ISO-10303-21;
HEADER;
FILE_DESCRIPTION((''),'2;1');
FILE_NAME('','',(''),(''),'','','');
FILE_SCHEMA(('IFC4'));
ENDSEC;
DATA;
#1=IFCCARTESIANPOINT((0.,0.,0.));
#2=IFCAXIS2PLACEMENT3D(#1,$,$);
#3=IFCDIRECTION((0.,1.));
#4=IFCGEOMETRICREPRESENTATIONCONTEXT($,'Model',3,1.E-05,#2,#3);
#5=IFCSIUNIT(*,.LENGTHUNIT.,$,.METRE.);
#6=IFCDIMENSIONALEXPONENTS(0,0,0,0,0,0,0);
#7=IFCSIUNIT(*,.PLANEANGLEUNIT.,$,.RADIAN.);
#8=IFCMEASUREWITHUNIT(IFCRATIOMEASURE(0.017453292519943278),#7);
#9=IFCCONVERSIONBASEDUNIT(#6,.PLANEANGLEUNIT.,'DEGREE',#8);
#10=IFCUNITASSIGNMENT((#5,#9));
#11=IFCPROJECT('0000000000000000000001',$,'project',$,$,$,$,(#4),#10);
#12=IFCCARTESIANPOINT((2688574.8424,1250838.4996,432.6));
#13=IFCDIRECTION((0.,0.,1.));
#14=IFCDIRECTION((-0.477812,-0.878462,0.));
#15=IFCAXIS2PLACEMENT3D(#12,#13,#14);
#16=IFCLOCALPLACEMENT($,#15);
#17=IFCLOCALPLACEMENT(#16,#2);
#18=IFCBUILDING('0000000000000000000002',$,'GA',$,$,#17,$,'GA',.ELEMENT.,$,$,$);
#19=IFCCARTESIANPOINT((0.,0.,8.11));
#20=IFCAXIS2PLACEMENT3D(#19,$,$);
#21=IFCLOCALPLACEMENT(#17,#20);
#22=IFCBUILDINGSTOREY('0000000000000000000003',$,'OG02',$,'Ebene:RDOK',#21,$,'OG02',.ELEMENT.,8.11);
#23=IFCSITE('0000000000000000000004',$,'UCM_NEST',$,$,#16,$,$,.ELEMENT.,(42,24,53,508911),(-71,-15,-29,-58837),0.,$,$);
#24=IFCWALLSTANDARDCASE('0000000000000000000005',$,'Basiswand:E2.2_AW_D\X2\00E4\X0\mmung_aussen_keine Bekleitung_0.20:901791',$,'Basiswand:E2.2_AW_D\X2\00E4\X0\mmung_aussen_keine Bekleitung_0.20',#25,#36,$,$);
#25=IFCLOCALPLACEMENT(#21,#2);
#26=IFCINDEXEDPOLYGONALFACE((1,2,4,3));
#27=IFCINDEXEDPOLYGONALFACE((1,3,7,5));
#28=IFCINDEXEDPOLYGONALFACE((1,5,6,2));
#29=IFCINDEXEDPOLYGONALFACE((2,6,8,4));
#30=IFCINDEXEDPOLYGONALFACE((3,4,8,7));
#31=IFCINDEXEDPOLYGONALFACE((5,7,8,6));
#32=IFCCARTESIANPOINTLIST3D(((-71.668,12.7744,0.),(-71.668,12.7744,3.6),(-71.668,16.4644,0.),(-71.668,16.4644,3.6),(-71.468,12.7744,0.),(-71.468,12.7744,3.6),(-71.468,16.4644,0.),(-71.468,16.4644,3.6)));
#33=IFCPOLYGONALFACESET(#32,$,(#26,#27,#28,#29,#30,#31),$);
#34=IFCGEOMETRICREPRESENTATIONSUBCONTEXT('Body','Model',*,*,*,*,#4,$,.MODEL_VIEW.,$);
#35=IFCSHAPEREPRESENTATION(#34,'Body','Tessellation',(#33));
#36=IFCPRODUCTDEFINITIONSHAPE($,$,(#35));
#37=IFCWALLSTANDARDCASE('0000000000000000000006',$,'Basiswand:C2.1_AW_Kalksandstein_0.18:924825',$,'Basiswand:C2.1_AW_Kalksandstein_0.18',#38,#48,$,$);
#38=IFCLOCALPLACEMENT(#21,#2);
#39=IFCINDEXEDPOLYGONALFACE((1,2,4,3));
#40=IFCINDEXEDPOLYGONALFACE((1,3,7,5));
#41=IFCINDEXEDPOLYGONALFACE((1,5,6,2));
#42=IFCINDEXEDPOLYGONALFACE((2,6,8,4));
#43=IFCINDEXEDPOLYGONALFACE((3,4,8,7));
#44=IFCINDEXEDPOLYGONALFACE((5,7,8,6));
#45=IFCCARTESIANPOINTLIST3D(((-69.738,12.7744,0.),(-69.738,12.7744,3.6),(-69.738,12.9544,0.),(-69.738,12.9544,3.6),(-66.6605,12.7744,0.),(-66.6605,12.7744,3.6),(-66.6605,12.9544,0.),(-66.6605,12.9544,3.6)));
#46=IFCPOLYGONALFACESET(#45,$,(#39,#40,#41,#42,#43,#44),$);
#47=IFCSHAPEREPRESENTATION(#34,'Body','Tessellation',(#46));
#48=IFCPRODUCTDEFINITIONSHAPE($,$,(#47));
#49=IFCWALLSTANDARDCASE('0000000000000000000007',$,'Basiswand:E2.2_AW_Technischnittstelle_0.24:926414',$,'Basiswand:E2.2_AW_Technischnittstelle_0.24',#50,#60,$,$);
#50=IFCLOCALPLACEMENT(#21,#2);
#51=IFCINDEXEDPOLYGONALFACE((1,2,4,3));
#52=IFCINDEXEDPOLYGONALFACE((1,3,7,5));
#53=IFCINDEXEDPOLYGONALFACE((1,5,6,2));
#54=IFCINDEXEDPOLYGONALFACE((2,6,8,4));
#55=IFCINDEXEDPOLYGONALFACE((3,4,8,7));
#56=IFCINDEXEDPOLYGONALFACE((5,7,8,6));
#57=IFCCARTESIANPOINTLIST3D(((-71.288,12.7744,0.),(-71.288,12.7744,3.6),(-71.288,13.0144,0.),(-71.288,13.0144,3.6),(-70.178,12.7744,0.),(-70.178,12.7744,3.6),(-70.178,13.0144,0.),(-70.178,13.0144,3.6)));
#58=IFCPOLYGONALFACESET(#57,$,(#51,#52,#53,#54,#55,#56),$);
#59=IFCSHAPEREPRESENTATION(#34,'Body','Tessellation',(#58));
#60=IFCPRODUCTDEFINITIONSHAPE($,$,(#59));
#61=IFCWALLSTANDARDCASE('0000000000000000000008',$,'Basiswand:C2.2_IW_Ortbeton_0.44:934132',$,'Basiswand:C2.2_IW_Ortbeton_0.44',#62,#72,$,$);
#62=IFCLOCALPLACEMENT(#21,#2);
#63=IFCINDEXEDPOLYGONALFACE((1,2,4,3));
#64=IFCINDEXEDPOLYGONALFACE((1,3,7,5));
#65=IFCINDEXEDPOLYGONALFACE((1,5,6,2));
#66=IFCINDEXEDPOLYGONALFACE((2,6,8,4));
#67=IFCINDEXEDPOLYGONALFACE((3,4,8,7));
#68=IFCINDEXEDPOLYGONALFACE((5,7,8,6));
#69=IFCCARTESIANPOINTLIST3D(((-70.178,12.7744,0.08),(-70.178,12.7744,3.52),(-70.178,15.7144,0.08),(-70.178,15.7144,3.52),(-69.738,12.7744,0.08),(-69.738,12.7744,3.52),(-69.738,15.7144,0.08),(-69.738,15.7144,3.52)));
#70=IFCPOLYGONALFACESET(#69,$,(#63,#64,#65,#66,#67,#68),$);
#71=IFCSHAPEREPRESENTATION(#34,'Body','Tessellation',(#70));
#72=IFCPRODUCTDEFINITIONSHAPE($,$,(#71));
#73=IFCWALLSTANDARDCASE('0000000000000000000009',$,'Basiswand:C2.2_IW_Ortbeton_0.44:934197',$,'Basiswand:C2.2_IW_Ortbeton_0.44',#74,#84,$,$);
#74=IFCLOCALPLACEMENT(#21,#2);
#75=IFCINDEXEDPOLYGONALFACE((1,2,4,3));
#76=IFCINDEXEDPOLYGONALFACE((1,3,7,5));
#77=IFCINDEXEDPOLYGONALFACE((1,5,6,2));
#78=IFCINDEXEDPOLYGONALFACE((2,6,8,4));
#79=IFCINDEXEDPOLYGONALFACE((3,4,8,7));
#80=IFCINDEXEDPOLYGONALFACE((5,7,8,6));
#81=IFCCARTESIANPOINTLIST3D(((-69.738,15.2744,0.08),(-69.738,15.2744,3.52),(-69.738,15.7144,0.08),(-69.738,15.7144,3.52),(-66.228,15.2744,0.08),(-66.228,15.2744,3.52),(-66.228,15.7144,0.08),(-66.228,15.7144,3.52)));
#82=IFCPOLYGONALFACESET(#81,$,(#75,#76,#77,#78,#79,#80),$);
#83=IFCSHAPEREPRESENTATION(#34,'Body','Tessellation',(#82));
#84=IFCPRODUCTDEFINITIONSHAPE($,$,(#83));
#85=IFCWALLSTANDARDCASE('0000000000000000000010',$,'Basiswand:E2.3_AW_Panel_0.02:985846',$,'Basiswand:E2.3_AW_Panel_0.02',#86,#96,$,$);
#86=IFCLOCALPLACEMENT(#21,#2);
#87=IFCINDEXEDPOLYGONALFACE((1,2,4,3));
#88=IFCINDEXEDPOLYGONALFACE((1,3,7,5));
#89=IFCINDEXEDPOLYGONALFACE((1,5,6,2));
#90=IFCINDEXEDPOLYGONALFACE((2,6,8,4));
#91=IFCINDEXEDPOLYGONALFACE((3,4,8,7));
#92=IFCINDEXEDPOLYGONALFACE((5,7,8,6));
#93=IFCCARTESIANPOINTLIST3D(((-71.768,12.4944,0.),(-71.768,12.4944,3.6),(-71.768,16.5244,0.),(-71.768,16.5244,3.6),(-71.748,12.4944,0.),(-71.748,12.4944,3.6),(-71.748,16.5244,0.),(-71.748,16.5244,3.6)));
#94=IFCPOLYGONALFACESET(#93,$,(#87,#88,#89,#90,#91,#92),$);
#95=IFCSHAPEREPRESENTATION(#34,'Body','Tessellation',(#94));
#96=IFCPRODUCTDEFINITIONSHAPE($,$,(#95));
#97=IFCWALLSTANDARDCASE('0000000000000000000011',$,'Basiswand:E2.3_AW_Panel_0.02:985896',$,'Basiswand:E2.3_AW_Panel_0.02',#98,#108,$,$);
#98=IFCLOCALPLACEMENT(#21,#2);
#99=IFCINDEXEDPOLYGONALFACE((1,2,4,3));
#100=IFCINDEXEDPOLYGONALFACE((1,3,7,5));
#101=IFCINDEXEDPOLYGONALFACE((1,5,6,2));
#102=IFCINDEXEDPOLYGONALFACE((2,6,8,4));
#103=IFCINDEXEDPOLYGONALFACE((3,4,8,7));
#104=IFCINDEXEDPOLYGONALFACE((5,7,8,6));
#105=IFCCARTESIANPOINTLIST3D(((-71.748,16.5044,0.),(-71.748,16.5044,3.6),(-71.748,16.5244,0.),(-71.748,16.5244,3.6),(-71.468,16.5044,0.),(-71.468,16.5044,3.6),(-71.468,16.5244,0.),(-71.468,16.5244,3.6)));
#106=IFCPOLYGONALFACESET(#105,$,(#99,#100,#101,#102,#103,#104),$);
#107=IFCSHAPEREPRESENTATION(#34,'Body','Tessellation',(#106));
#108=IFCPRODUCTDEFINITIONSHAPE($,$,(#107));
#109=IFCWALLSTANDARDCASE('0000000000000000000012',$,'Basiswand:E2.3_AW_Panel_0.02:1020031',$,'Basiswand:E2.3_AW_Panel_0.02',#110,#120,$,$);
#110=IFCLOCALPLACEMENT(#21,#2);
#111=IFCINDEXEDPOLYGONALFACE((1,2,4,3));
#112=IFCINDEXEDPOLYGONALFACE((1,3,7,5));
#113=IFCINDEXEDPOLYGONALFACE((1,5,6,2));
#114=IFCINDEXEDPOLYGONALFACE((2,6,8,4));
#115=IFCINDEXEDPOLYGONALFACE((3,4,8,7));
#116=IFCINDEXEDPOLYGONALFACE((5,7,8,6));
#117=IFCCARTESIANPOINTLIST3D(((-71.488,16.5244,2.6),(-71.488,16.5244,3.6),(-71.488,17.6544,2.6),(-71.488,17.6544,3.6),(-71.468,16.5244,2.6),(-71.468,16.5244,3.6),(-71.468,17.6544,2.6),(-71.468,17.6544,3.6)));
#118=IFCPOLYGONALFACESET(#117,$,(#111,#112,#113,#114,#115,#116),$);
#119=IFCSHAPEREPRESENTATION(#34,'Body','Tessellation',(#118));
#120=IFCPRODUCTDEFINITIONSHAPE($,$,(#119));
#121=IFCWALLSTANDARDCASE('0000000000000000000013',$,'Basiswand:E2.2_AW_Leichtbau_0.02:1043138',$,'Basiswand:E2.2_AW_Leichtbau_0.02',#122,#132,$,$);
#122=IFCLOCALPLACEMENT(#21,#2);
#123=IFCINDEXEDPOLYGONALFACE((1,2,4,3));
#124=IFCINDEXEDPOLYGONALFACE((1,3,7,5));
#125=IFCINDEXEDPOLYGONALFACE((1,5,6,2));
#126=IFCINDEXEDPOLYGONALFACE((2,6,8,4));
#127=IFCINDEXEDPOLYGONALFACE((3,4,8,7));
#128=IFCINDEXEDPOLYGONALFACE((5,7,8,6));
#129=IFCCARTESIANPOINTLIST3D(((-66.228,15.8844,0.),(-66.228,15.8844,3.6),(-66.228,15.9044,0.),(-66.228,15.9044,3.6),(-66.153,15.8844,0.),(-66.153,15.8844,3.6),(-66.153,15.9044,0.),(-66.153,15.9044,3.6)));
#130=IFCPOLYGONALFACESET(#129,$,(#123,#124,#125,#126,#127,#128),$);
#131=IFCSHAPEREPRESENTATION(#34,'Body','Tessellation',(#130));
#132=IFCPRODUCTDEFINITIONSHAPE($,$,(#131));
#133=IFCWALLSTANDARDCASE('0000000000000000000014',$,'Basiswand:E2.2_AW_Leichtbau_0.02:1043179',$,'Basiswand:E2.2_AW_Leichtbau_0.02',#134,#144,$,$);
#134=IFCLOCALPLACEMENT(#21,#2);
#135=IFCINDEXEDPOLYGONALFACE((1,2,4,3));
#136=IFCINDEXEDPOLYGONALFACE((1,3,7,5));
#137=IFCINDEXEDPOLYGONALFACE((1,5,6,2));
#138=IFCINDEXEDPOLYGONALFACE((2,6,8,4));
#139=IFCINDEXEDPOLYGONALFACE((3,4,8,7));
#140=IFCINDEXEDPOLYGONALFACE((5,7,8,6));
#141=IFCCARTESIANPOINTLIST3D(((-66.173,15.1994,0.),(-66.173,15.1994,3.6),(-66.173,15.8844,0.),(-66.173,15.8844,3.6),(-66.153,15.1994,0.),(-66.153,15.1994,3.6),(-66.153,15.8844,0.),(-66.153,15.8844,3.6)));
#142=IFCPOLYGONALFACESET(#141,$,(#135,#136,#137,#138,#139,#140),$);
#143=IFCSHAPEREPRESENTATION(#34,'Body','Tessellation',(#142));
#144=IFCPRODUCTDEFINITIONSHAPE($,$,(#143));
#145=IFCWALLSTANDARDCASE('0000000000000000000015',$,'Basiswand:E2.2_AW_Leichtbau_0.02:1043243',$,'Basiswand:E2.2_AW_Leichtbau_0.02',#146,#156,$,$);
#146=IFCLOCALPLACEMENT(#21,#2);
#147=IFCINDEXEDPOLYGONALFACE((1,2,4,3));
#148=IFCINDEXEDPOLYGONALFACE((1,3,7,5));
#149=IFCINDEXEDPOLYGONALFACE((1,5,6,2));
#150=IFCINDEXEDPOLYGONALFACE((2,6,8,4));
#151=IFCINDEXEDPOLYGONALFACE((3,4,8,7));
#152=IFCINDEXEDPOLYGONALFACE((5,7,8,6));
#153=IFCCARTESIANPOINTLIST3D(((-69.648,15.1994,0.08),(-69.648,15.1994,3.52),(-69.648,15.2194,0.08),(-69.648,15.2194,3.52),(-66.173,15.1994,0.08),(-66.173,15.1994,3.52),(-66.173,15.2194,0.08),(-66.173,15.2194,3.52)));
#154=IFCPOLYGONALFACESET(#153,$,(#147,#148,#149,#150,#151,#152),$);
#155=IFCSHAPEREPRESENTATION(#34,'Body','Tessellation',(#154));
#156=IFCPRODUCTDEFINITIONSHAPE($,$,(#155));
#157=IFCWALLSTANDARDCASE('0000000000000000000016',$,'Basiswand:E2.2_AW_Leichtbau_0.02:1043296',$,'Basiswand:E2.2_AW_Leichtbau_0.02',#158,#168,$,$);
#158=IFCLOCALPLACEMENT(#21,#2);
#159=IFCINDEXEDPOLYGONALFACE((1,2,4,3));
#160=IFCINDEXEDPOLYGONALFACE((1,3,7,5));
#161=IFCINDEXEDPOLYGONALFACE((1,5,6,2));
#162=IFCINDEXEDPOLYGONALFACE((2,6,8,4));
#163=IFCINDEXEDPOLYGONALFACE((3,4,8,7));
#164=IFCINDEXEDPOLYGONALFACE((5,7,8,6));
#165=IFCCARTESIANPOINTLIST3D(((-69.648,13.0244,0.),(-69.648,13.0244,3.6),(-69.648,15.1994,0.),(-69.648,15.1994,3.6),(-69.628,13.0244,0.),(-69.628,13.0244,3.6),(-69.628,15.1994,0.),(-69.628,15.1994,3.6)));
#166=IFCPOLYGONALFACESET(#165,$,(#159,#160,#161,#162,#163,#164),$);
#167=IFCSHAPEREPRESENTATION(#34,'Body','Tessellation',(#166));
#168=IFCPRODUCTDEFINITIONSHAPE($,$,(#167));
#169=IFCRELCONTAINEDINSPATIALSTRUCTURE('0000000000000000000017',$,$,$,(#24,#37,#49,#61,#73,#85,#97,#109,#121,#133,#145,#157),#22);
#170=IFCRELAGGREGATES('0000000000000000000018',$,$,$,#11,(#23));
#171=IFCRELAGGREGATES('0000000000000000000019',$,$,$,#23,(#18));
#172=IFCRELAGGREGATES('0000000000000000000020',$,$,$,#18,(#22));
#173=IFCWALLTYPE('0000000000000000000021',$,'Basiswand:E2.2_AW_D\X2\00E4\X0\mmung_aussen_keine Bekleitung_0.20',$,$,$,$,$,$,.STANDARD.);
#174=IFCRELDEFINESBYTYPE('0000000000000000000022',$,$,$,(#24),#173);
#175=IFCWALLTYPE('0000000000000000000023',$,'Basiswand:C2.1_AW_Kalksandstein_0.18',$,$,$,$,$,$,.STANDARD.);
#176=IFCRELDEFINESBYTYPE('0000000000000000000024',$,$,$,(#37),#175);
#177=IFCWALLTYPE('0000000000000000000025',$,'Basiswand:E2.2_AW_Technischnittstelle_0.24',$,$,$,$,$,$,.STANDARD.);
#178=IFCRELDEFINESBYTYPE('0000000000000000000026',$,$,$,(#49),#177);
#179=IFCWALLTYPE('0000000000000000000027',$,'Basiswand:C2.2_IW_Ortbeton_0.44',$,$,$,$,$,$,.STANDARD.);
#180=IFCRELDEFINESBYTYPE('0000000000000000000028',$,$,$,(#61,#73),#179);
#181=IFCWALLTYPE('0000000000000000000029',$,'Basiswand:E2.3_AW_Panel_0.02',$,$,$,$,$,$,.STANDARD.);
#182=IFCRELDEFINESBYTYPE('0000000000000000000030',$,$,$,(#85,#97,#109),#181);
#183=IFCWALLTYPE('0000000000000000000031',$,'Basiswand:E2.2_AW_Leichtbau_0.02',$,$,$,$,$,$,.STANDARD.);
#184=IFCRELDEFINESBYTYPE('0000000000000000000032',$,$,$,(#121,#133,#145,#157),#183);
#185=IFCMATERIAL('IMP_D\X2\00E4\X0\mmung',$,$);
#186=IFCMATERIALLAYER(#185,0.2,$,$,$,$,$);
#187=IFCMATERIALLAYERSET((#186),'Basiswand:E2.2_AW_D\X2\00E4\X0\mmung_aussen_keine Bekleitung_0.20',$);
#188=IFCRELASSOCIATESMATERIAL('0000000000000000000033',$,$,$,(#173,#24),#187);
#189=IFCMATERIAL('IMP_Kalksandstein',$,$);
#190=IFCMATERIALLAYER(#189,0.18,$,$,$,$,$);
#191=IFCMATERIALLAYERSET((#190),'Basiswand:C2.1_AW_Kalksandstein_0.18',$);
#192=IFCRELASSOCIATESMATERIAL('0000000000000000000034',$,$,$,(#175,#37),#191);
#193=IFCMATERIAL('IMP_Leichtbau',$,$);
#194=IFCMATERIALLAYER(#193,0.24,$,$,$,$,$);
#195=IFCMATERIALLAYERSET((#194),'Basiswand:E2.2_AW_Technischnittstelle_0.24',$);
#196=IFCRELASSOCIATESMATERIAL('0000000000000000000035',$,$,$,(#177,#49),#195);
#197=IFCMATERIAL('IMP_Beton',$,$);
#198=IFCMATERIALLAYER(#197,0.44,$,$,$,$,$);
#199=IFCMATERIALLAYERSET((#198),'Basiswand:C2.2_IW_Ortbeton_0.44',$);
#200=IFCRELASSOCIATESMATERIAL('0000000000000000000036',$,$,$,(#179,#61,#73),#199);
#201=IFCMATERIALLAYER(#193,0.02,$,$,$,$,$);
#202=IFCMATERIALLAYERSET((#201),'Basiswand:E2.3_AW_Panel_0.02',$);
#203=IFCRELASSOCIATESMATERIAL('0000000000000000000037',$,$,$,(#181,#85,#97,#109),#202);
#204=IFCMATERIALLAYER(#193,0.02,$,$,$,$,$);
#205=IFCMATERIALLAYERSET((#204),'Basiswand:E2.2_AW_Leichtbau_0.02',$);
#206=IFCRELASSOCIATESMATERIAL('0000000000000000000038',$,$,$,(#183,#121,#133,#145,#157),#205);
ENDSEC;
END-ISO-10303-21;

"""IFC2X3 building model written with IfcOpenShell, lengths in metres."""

from ifc_helpers import new_model, entity, si_unit, converted_unit, direction, frame, frame_2d, origin, place, context, subcontext, project, spatial, polyline, rectangle, extrude, clip, bounded_halfspace, material, layer, layer_set, layer_usage, type_object, element, save


model = new_model("IFC2X3")

# Units and contexts
model_context = context("Model", 3, precision=1e-05, world=origin(), true_north=direction((0.0, 1.0)))
body_context = subcontext(model_context, "Body", "Model", "MODEL_VIEW")
ifc_project = project(units=[si_unit("LENGTHUNIT", "METRE"), converted_unit("PLANEANGLEUNIT", "DEGREE", entity("IfcRatioMeasure", 0.017453292519943278), si_unit("PLANEANGLEUNIT", "RADIAN"), dimensions=[0, 0, 0, 0, 0, 0, 0])], contexts=[model_context])

# Site, building, storey
site_placement = place(None, frame((2688574.8424, 1250838.4996, 432.6), z_axis=(0.0, 0.0, 1.0), x_axis=(-0.477812, -0.878462, 0.0)))
site = spatial("IfcSite", under=ifc_project, at=site_placement, Name="UCM_NEST", CompositionType="ELEMENT", RefLatitude=(42, 24, 53, 508911), RefLongitude=(-71, -15, -29, -58837), RefElevation=0.0)
building_placement = place(site_placement, origin())
building = spatial("IfcBuilding", under=site, at=building_placement, Name="GA", LongName="GA", CompositionType="ELEMENT")
storey_placement = place(building_placement, frame((0.0, 0.0, 8.11)))
storey = spatial("IfcBuildingStorey", under=building, at=storey_placement, Name="OG02", ObjectType="Ebene:RDOK", LongName="OG02", CompositionType="ELEMENT", Elevation=8.11)

# Walls
ifc_material_1 = material(Name="IMP_Dämmung")
ifc_layer_1 = layer(ifc_material_1, 0.2)
ifc_layer_set_1 = layer_set([ifc_layer_1], Name="Basiswand:E2.2_AW_Dämmung_aussen_keine Bekleitung_0.20")
ifc_layer_usage_1 = layer_usage(ifc_layer_set_1, "AXIS2", "NEGATIVE", 0.1)
wall_type_1 = type_object("IfcWallType", Name="Basiswand:E2.2_AW_Dämmung_aussen_keine Bekleitung_0.20", PredefinedType="STANDARD", material=ifc_layer_set_1)
wall_1_placement = place(storey_placement, frame((-71.568, 12.7744, 0.0), z_axis=(0.0, 0.0, 1.0), x_axis=(0.0, 1.0, 0.0)))
element("IfcWallStandardCase", 1, at=wall_1_placement, inside=storey, type_object=wall_type_1, material=ifc_layer_usage_1, Name="Basiswand:E2.2_AW_Dämmung_aussen_keine Bekleitung_0.20:901791", ObjectType="Basiswand:E2.2_AW_Dämmung_aussen_keine Bekleitung_0.20", context=body_context, shape_type="SweptSolid", body=[
    extrude(rectangle(XDim=3.69, YDim=0.2, at=frame_2d((1.845, 0.0), x_axis=(-1.0, 0.0))), origin(), (0.0, 0.0, 1.0), 3.6),
])
ifc_material_2 = material(Name="IMP_Kalksandstein")
ifc_layer_2 = layer(ifc_material_2, 0.18)
ifc_layer_set_2 = layer_set([ifc_layer_2], Name="Basiswand:C2.1_AW_Kalksandstein_0.18")
ifc_layer_usage_2 = layer_usage(ifc_layer_set_2, "AXIS2", "NEGATIVE", 0.09)
wall_type_2 = type_object("IfcWallType", Name="Basiswand:C2.1_AW_Kalksandstein_0.18", PredefinedType="STANDARD", material=ifc_layer_set_2)
wall_2_placement = place(storey_placement, frame((-66.6605, 12.8644, 0.0), z_axis=(0.0, 0.0, 1.0), x_axis=(-1.0, 0.0, 0.0)))
element("IfcWallStandardCase", 2, at=wall_2_placement, inside=storey, type_object=wall_type_2, material=ifc_layer_usage_2, Name="Basiswand:C2.1_AW_Kalksandstein_0.18:924825", ObjectType="Basiswand:C2.1_AW_Kalksandstein_0.18", context=body_context, shape_type="SweptSolid", body=[
    extrude(rectangle(XDim=3.0775, YDim=0.18, at=frame_2d((1.5388, 0.0), x_axis=(-1.0, 0.0))), origin(), (0.0, 0.0, 1.0), 3.6),
])
ifc_material_3 = material(Name="IMP_Leichtbau")
ifc_layer_3 = layer(ifc_material_3, 0.24)
ifc_layer_set_3 = layer_set([ifc_layer_3], Name="Basiswand:E2.2_AW_Technischnittstelle_0.24")
ifc_layer_usage_3 = layer_usage(ifc_layer_set_3, "AXIS2", "NEGATIVE", 0.12)
wall_type_3 = type_object("IfcWallType", Name="Basiswand:E2.2_AW_Technischnittstelle_0.24", PredefinedType="STANDARD", material=ifc_layer_set_3)
wall_3_placement = place(storey_placement, frame((-70.178, 12.8944, 0.0), z_axis=(0.0, 0.0, 1.0), x_axis=(-1.0, 0.0, 0.0)))
element("IfcWallStandardCase", 3, at=wall_3_placement, inside=storey, type_object=wall_type_3, material=ifc_layer_usage_3, Name="Basiswand:E2.2_AW_Technischnittstelle_0.24:926414", ObjectType="Basiswand:E2.2_AW_Technischnittstelle_0.24", context=body_context, shape_type="SweptSolid", body=[
    extrude(rectangle(XDim=1.11, YDim=0.24, at=frame_2d((0.555, 0.0), x_axis=(-1.0, 0.0))), origin(), (0.0, 0.0, 1.0), 3.6),
])

# Shared definitions
ifc_material_4 = material(Name="IMP_Beton")

# Walls
ifc_layer_4 = layer(ifc_material_4, 0.44)
ifc_layer_set_4 = layer_set([ifc_layer_4], Name="Basiswand:C2.2_IW_Ortbeton_0.44")
ifc_layer_usage_4 = layer_usage(ifc_layer_set_4, "AXIS2", "NEGATIVE", 0.22)
wall_type_4 = type_object("IfcWallType", Name="Basiswand:C2.2_IW_Ortbeton_0.44", PredefinedType="STANDARD", material=ifc_layer_set_4)
wall_4_placement = place(storey_placement, frame((-69.958, 12.7744, 0.08), z_axis=(0.0, 0.0, 1.0), x_axis=(0.0, 1.0, 0.0)))
element("IfcWallStandardCase", 4, at=wall_4_placement, inside=storey, type_object=wall_type_4, material=ifc_layer_usage_4, Name="Basiswand:C2.2_IW_Ortbeton_0.44:934132", ObjectType="Basiswand:C2.2_IW_Ortbeton_0.44", context=body_context, shape_type="Clipping", body=[
    clip(clip(extrude(rectangle(XDim=2.94, YDim=0.44, at=frame_2d((1.47, 0.0), x_axis=(-1.0, 0.0))), origin(), (0.0, 0.0, 1.0), 3.44), bounded_halfspace(frame((2.94, -0.22, 0.0), z_axis=(0.0, 0.0, 1.0), x_axis=(0.0, 1.0, 0.0)), True, frame((2.94, -0.22, 0.0), z_axis=(0.0, 0.0, 1.0), x_axis=(0.0, 1.0, 0.0)), polyline([(0.0, 0.0), (0.44, 0.0), (0.44, 2.94), (0.0, 2.94), (0.0, 2.76), (0.0, 0.44), (0.0, 0.0)]))), bounded_halfspace(frame((0.0, -0.22, 3.44), z_axis=(0.0, 0.0, -1.0), x_axis=(0.0, 1.0, 0.0)), True, frame((0.0, -0.22, 3.44), z_axis=(0.0, 0.0, -1.0), x_axis=(0.0, 1.0, 0.0)), polyline([(0.0, 0.0), (0.44, 0.0), (0.44, 2.94), (0.0, 2.94), (0.0, 2.5), (0.0, 0.18), (0.0, 0.0)]))),
])
wall_5_placement = place(storey_placement, frame((-69.738, 15.4944, 0.08)))
element("IfcWallStandardCase", 5, at=wall_5_placement, inside=storey, type_object=wall_type_4, material=ifc_layer_usage_4, Name="Basiswand:C2.2_IW_Ortbeton_0.44:934197", ObjectType="Basiswand:C2.2_IW_Ortbeton_0.44", context=body_context, shape_type="Clipping", body=[
    clip(clip(extrude(rectangle(XDim=3.51, YDim=0.44, at=frame_2d((1.755, 0.0), x_axis=(-1.0, 0.0))), origin(), (0.0, 0.0, 1.0), 3.44), bounded_halfspace(frame((0.0, -0.22, 3.44), z_axis=(0.0, 0.0, -1.0), x_axis=(-1.0, 0.0, 0.0)), True, frame((0.0, -0.22, 3.44), z_axis=(0.0, 0.0, -1.0), x_axis=(-1.0, 0.0, 0.0)), polyline([(0.0, 0.0), (0.0, 0.44), (-3.26, 0.44), (-3.51, 0.44), (-3.51, 0.0), (0.0, 0.0)]))), bounded_halfspace(frame((3.51, -0.22, 0.0), z_axis=(0.0, 0.0, 1.0), x_axis=(-1.0, 0.0, 0.0)), True, frame((3.51, -0.22, 0.0), z_axis=(0.0, 0.0, 1.0), x_axis=(-1.0, 0.0, 0.0)), polyline([(0.0, 0.0), (0.0, -0.44), (3.51, -0.44), (3.51, 0.0), (0.0, 0.0)]))),
])

# Walls
ifc_layer_5 = layer(ifc_material_3, 0.02)
ifc_layer_set_5 = layer_set([ifc_layer_5], Name="Basiswand:E2.3_AW_Panel_0.02")
ifc_layer_usage_5 = layer_usage(ifc_layer_set_5, "AXIS2", "NEGATIVE", 0.01)
wall_type_5 = type_object("IfcWallType", Name="Basiswand:E2.3_AW_Panel_0.02", PredefinedType="STANDARD", material=ifc_layer_set_5)
wall_6_placement = place(storey_placement, frame((-71.758, 12.4944, 0.0), z_axis=(0.0, 0.0, 1.0), x_axis=(0.0, 1.0, 0.0)))
element("IfcWallStandardCase", 6, at=wall_6_placement, inside=storey, type_object=wall_type_5, material=ifc_layer_usage_5, Name="Basiswand:E2.3_AW_Panel_0.02:985846", ObjectType="Basiswand:E2.3_AW_Panel_0.02", context=body_context, shape_type="SweptSolid", body=[
    extrude(rectangle(XDim=4.03, YDim=0.02, at=frame_2d((2.015, 0.0), x_axis=(-1.0, 0.0))), origin(), (0.0, 0.0, 1.0), 3.6),
])
wall_7_placement = place(storey_placement, frame((-71.748, 16.5144, 0.0)))
element("IfcWallStandardCase", 7, at=wall_7_placement, inside=storey, type_object=wall_type_5, material=ifc_layer_usage_5, Name="Basiswand:E2.3_AW_Panel_0.02:985896", ObjectType="Basiswand:E2.3_AW_Panel_0.02", context=body_context, shape_type="SweptSolid", body=[
    extrude(rectangle(XDim=0.28, YDim=0.02, at=frame_2d((0.14, 0.0), x_axis=(-1.0, 0.0))), origin(), (0.0, 0.0, 1.0), 3.6),
])
wall_8_placement = place(storey_placement, frame((-71.478, 16.5244, 2.6), z_axis=(0.0, 0.0, 1.0), x_axis=(0.0, 1.0, 0.0)))
element("IfcWallStandardCase", 8, at=wall_8_placement, inside=storey, type_object=wall_type_5, material=ifc_layer_usage_5, Name="Basiswand:E2.3_AW_Panel_0.02:1020031", ObjectType="Basiswand:E2.3_AW_Panel_0.02", context=body_context, shape_type="SweptSolid", body=[
    extrude(rectangle(XDim=1.13, YDim=0.02, at=frame_2d((0.565, 0.0), x_axis=(-1.0, 0.0))), origin(), (0.0, 0.0, 1.0), 1.0),
])

# Walls
ifc_layer_6 = layer(ifc_material_3, 0.02)
ifc_layer_set_6 = layer_set([ifc_layer_6], Name="Basiswand:E2.2_AW_Leichtbau_0.02")
ifc_layer_usage_6 = layer_usage(ifc_layer_set_6, "AXIS2", "NEGATIVE", 0.01)
wall_type_6 = type_object("IfcWallType", Name="Basiswand:E2.2_AW_Leichtbau_0.02", PredefinedType="STANDARD", material=ifc_layer_set_6)
wall_9_placement = place(storey_placement, frame((-66.228, 15.8944, 0.0)))
element("IfcWallStandardCase", 9, at=wall_9_placement, inside=storey, type_object=wall_type_6, material=ifc_layer_usage_6, Name="Basiswand:E2.2_AW_Leichtbau_0.02:1043138", ObjectType="Basiswand:E2.2_AW_Leichtbau_0.02", context=body_context, shape_type="SweptSolid", body=[
    extrude(rectangle(XDim=0.075, YDim=0.02, at=frame_2d((0.0375, 0.0), x_axis=(-1.0, 0.0))), origin(), (0.0, 0.0, 1.0), 3.6),
])
wall_10_placement = place(storey_placement, frame((-66.163, 15.8844, 0.0), z_axis=(0.0, 0.0, 1.0), x_axis=(0.0, -1.0, 0.0)))
element("IfcWallStandardCase", 10, at=wall_10_placement, inside=storey, type_object=wall_type_6, material=ifc_layer_usage_6, Name="Basiswand:E2.2_AW_Leichtbau_0.02:1043179", ObjectType="Basiswand:E2.2_AW_Leichtbau_0.02", context=body_context, shape_type="SweptSolid", body=[
    extrude(rectangle(XDim=0.685, YDim=0.02, at=frame_2d((0.3425, 0.0), x_axis=(-1.0, 0.0))), origin(), (0.0, 0.0, 1.0), 3.6),
])
wall_11_placement = place(storey_placement, frame((-66.173, 15.2094, 0.08), z_axis=(0.0, 0.0, 1.0), x_axis=(-1.0, 0.0, 0.0)))
element("IfcWallStandardCase", 11, at=wall_11_placement, inside=storey, type_object=wall_type_6, material=ifc_layer_usage_6, Name="Basiswand:E2.2_AW_Leichtbau_0.02:1043243", ObjectType="Basiswand:E2.2_AW_Leichtbau_0.02", context=body_context, shape_type="Clipping", body=[
    clip(clip(extrude(rectangle(XDim=3.475, YDim=0.02, at=frame_2d((1.7375, 0.0), x_axis=(-1.0, 0.0))), origin(), (0.0, 0.0, 1.0), 3.44), bounded_halfspace(frame((3.475, -0.01, 0.0)), True, frame((3.475, -0.01, 0.0)), polyline([(0.0, 0.0), (0.0, 0.02), (-3.475, 0.02), (-3.475, 0.0), (0.0, 0.0)]))), bounded_halfspace(frame((0.0, -0.01, 3.44), z_axis=(0.0, 0.0, -1.0), x_axis=(1.0, 0.0, 0.0)), True, frame((0.0, -0.01, 3.44), z_axis=(0.0, 0.0, -1.0), x_axis=(1.0, 0.0, 0.0)), polyline([(0.0, 0.0), (0.0, -0.02), (3.475, -0.02), (3.475, 0.0), (0.0, 0.0)]))),
])
wall_12_placement = place(storey_placement, frame((-69.638, 15.1994, 0.0), z_axis=(0.0, 0.0, 1.0), x_axis=(0.0, -1.0, 0.0)))
element("IfcWallStandardCase", 12, at=wall_12_placement, inside=storey, type_object=wall_type_6, material=ifc_layer_usage_6, Name="Basiswand:E2.2_AW_Leichtbau_0.02:1043296", ObjectType="Basiswand:E2.2_AW_Leichtbau_0.02", context=body_context, shape_type="SweptSolid", body=[
    extrude(rectangle(XDim=2.175, YDim=0.02, at=frame_2d((1.0875, 0.0), x_axis=(-1.0, 0.0))), origin(), (0.0, 0.0, 1.0), 3.6),
])

save(model, "model.ifc")
